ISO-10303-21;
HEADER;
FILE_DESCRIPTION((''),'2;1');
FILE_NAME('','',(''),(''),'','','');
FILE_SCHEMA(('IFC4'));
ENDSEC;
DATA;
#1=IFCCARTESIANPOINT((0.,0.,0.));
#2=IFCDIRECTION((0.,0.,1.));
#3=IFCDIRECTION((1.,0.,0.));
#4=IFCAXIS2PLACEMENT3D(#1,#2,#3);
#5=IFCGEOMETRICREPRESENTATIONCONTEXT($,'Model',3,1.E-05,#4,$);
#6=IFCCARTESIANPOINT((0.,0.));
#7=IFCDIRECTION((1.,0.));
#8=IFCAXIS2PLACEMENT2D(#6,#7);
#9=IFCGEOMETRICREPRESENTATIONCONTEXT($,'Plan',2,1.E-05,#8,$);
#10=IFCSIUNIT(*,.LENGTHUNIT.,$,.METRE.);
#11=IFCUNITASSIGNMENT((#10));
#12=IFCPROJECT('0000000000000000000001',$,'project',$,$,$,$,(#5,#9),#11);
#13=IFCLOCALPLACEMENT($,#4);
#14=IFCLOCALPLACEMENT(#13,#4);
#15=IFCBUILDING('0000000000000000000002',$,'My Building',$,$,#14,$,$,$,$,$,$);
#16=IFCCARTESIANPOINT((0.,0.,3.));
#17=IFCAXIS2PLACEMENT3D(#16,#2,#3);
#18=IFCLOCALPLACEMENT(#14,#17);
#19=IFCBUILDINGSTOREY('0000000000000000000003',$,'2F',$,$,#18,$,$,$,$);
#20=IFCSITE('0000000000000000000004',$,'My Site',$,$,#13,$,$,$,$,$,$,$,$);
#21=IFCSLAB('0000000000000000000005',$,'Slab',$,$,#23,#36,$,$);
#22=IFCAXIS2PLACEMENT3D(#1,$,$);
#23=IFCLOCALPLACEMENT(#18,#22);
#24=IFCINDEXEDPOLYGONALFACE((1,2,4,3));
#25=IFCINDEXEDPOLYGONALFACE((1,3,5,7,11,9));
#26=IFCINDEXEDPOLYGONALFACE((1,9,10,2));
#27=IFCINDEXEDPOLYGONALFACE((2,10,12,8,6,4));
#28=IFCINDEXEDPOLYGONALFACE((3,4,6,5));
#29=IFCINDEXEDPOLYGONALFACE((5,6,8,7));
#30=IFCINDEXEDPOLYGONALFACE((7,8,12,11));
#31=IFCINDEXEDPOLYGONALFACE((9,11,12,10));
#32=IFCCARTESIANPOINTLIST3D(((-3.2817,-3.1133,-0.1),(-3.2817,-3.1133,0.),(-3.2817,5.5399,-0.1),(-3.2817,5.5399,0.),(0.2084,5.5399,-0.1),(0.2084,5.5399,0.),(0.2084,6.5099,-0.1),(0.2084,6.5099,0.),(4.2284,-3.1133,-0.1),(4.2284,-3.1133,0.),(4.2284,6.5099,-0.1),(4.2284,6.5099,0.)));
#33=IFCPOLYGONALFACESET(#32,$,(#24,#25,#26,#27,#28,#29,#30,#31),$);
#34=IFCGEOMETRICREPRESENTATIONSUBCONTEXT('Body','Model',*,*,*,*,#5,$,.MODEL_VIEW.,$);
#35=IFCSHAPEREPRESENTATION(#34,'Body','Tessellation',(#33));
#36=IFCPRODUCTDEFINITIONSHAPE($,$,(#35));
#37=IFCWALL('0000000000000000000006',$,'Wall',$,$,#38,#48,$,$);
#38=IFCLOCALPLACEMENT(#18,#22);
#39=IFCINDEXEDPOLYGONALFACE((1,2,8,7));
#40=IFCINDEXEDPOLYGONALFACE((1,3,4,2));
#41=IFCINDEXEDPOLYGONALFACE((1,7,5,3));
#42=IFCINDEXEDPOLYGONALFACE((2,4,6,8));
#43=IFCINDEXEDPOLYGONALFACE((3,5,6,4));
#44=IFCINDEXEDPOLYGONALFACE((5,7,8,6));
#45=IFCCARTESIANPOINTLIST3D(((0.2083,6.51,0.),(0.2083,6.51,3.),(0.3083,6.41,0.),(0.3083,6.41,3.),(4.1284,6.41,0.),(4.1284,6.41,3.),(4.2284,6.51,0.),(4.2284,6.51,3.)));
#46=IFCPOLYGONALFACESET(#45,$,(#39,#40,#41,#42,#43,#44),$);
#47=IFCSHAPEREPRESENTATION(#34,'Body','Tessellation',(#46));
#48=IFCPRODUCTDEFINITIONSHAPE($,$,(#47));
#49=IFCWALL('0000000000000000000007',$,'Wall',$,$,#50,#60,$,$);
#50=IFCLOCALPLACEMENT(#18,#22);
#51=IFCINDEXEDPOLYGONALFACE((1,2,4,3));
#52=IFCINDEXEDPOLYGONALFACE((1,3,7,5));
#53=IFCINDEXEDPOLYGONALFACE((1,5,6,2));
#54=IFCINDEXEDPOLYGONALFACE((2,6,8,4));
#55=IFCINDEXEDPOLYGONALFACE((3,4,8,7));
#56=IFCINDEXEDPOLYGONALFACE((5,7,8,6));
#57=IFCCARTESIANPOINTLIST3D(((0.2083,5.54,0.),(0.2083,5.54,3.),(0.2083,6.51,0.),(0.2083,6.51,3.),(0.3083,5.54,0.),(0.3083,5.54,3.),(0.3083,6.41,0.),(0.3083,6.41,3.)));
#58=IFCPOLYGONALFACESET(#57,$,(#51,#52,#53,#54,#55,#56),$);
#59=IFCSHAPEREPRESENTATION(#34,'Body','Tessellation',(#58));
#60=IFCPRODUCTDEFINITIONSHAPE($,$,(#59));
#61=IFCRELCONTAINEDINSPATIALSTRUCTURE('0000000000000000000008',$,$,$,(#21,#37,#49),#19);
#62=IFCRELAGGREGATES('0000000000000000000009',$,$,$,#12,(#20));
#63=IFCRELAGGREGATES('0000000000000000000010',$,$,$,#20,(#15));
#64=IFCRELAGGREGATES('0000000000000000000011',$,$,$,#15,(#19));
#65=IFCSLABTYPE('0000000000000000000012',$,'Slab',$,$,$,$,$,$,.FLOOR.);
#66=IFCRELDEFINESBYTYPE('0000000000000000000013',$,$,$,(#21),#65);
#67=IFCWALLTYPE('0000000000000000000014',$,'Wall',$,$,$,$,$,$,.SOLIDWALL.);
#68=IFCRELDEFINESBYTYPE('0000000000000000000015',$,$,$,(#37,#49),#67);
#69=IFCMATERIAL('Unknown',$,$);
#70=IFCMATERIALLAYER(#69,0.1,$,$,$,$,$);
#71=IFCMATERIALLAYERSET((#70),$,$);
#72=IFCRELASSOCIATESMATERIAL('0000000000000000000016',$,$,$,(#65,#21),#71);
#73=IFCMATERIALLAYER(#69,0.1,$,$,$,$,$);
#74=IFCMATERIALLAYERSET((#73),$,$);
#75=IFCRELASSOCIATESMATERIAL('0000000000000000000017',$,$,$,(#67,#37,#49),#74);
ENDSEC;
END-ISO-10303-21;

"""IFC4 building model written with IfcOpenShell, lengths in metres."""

from ifc_helpers import new_model, si_unit, frame, origin_with_axes, origin_2d_with_axis, place, context, subcontext, project, spatial, line, indexed_curve, outline, extrude, material, layer, layer_set, layer_usage, type_object, element, save


model = new_model("IFC4")

# Units and contexts
model_context_1 = context("Model", 3, precision=1e-05, world=origin_with_axes())
plan_context = context("Plan", 2, precision=1e-05, world=origin_2d_with_axis())
body_context_1 = subcontext(model_context_1, "Body", "Model", "MODEL_VIEW")
ifc_project = project(units=[si_unit("LENGTHUNIT", "METRE")], contexts=[model_context_1, plan_context])

# Site, building, storey
site_placement = place(None, origin_with_axes())
site = spatial("IfcSite", under=ifc_project, at=site_placement, Name="My Site")
building_placement = place(site_placement, origin_with_axes())
building = spatial("IfcBuilding", under=site, at=building_placement, Name="My Building")
storey_placement = place(building_placement, frame((0.0, 0.0, 3.0), z_axis=(0.0, 0.0, 1.0), x_axis=(1.0, 0.0, 0.0)))
storey = spatial("IfcBuildingStorey", under=building, at=storey_placement, Name="2F")

# Slab
ifc_material = material(Name="Unknown")
ifc_layer_1 = layer(ifc_material, 0.1)
ifc_layer_set_1 = layer_set([ifc_layer_1])
ifc_layer_usage_1 = layer_usage(ifc_layer_set_1, "AXIS3", "POSITIVE", -0.1)
slab_type = type_object("IfcSlabType", Name="Slab", PredefinedType="FLOOR", material=ifc_layer_set_1)
slab_placement = place(storey_placement, frame((4.2284, 6.5099, 0.0), z_axis=(0.0, 0.0, 1.0), x_axis=(1.0, 0.0, 0.0)))
element("IfcSlab", 1, at=slab_placement, inside=storey, type_object=slab_type, material=ifc_layer_usage_1, Name="Slab", context=body_context_1, shape_type="SweptSolid", body=[
    extrude(outline(indexed_curve([(0.0, 0.0), (-4.02, 0.0), (-4.02, -0.97), (-7.5101, -0.97), (-7.5101, -9.6233), (0.0, -9.6233), (0.0, 0.0)])), frame((0.0, 0.0, -0.1), z_axis=(0.0, 0.0, 1.0), x_axis=(1.0, 0.0, 0.0)), (0.0, 0.0, 1.0), 0.1),
])

# Walls
ifc_layer_2 = layer(ifc_material, 0.1)
ifc_layer_set_2 = layer_set([ifc_layer_2])
ifc_layer_usage_2 = layer_usage(ifc_layer_set_2, "AXIS2", "POSITIVE", 0.0)
wall_type = type_object("IfcWallType", Name="Wall", PredefinedType="SOLIDWALL", material=ifc_layer_set_2)
wall_1_placement = place(storey_placement, frame((4.2284, 6.51, 0.0), z_axis=(0.0, 0.0, 1.0), x_axis=(-1.0, 0.0, 0.0)))
element("IfcWall", 2, at=wall_1_placement, inside=storey, type_object=wall_type, material=ifc_layer_usage_2, Name="Wall", context=body_context_1, shape_type="SweptSolid", body=[
    extrude(outline(indexed_curve([(0.0, 0.0), (0.1, 0.1), (3.92, 0.1), (4.02, 0.0)], segments=[line(1, 2, 3, 4, 1)])), origin_with_axes(), (0.0, 0.0, 1.0), 3.0),
])
ifc_layer_usage_3 = layer_usage(ifc_layer_set_2, "AXIS2", "POSITIVE", 0.0)
wall_2_placement = place(storey_placement, frame((0.2083, 6.51, 0.0), z_axis=(0.0, 0.0, 1.0), x_axis=(0.0, -1.0, 0.0)))
element("IfcWall", 3, at=wall_2_placement, inside=storey, type_object=wall_type, material=ifc_layer_usage_3, Name="Wall", context=body_context_1, shape_type="SweptSolid", body=[
    extrude(outline(indexed_curve([(0.0, 0.0), (0.1, 0.1), (0.97, 0.1), (0.97, 0.0)], segments=[line(1, 2, 3, 4, 1)])), origin_with_axes(), (0.0, 0.0, 1.0), 3.0),
])

save(model, "model.ifc")
